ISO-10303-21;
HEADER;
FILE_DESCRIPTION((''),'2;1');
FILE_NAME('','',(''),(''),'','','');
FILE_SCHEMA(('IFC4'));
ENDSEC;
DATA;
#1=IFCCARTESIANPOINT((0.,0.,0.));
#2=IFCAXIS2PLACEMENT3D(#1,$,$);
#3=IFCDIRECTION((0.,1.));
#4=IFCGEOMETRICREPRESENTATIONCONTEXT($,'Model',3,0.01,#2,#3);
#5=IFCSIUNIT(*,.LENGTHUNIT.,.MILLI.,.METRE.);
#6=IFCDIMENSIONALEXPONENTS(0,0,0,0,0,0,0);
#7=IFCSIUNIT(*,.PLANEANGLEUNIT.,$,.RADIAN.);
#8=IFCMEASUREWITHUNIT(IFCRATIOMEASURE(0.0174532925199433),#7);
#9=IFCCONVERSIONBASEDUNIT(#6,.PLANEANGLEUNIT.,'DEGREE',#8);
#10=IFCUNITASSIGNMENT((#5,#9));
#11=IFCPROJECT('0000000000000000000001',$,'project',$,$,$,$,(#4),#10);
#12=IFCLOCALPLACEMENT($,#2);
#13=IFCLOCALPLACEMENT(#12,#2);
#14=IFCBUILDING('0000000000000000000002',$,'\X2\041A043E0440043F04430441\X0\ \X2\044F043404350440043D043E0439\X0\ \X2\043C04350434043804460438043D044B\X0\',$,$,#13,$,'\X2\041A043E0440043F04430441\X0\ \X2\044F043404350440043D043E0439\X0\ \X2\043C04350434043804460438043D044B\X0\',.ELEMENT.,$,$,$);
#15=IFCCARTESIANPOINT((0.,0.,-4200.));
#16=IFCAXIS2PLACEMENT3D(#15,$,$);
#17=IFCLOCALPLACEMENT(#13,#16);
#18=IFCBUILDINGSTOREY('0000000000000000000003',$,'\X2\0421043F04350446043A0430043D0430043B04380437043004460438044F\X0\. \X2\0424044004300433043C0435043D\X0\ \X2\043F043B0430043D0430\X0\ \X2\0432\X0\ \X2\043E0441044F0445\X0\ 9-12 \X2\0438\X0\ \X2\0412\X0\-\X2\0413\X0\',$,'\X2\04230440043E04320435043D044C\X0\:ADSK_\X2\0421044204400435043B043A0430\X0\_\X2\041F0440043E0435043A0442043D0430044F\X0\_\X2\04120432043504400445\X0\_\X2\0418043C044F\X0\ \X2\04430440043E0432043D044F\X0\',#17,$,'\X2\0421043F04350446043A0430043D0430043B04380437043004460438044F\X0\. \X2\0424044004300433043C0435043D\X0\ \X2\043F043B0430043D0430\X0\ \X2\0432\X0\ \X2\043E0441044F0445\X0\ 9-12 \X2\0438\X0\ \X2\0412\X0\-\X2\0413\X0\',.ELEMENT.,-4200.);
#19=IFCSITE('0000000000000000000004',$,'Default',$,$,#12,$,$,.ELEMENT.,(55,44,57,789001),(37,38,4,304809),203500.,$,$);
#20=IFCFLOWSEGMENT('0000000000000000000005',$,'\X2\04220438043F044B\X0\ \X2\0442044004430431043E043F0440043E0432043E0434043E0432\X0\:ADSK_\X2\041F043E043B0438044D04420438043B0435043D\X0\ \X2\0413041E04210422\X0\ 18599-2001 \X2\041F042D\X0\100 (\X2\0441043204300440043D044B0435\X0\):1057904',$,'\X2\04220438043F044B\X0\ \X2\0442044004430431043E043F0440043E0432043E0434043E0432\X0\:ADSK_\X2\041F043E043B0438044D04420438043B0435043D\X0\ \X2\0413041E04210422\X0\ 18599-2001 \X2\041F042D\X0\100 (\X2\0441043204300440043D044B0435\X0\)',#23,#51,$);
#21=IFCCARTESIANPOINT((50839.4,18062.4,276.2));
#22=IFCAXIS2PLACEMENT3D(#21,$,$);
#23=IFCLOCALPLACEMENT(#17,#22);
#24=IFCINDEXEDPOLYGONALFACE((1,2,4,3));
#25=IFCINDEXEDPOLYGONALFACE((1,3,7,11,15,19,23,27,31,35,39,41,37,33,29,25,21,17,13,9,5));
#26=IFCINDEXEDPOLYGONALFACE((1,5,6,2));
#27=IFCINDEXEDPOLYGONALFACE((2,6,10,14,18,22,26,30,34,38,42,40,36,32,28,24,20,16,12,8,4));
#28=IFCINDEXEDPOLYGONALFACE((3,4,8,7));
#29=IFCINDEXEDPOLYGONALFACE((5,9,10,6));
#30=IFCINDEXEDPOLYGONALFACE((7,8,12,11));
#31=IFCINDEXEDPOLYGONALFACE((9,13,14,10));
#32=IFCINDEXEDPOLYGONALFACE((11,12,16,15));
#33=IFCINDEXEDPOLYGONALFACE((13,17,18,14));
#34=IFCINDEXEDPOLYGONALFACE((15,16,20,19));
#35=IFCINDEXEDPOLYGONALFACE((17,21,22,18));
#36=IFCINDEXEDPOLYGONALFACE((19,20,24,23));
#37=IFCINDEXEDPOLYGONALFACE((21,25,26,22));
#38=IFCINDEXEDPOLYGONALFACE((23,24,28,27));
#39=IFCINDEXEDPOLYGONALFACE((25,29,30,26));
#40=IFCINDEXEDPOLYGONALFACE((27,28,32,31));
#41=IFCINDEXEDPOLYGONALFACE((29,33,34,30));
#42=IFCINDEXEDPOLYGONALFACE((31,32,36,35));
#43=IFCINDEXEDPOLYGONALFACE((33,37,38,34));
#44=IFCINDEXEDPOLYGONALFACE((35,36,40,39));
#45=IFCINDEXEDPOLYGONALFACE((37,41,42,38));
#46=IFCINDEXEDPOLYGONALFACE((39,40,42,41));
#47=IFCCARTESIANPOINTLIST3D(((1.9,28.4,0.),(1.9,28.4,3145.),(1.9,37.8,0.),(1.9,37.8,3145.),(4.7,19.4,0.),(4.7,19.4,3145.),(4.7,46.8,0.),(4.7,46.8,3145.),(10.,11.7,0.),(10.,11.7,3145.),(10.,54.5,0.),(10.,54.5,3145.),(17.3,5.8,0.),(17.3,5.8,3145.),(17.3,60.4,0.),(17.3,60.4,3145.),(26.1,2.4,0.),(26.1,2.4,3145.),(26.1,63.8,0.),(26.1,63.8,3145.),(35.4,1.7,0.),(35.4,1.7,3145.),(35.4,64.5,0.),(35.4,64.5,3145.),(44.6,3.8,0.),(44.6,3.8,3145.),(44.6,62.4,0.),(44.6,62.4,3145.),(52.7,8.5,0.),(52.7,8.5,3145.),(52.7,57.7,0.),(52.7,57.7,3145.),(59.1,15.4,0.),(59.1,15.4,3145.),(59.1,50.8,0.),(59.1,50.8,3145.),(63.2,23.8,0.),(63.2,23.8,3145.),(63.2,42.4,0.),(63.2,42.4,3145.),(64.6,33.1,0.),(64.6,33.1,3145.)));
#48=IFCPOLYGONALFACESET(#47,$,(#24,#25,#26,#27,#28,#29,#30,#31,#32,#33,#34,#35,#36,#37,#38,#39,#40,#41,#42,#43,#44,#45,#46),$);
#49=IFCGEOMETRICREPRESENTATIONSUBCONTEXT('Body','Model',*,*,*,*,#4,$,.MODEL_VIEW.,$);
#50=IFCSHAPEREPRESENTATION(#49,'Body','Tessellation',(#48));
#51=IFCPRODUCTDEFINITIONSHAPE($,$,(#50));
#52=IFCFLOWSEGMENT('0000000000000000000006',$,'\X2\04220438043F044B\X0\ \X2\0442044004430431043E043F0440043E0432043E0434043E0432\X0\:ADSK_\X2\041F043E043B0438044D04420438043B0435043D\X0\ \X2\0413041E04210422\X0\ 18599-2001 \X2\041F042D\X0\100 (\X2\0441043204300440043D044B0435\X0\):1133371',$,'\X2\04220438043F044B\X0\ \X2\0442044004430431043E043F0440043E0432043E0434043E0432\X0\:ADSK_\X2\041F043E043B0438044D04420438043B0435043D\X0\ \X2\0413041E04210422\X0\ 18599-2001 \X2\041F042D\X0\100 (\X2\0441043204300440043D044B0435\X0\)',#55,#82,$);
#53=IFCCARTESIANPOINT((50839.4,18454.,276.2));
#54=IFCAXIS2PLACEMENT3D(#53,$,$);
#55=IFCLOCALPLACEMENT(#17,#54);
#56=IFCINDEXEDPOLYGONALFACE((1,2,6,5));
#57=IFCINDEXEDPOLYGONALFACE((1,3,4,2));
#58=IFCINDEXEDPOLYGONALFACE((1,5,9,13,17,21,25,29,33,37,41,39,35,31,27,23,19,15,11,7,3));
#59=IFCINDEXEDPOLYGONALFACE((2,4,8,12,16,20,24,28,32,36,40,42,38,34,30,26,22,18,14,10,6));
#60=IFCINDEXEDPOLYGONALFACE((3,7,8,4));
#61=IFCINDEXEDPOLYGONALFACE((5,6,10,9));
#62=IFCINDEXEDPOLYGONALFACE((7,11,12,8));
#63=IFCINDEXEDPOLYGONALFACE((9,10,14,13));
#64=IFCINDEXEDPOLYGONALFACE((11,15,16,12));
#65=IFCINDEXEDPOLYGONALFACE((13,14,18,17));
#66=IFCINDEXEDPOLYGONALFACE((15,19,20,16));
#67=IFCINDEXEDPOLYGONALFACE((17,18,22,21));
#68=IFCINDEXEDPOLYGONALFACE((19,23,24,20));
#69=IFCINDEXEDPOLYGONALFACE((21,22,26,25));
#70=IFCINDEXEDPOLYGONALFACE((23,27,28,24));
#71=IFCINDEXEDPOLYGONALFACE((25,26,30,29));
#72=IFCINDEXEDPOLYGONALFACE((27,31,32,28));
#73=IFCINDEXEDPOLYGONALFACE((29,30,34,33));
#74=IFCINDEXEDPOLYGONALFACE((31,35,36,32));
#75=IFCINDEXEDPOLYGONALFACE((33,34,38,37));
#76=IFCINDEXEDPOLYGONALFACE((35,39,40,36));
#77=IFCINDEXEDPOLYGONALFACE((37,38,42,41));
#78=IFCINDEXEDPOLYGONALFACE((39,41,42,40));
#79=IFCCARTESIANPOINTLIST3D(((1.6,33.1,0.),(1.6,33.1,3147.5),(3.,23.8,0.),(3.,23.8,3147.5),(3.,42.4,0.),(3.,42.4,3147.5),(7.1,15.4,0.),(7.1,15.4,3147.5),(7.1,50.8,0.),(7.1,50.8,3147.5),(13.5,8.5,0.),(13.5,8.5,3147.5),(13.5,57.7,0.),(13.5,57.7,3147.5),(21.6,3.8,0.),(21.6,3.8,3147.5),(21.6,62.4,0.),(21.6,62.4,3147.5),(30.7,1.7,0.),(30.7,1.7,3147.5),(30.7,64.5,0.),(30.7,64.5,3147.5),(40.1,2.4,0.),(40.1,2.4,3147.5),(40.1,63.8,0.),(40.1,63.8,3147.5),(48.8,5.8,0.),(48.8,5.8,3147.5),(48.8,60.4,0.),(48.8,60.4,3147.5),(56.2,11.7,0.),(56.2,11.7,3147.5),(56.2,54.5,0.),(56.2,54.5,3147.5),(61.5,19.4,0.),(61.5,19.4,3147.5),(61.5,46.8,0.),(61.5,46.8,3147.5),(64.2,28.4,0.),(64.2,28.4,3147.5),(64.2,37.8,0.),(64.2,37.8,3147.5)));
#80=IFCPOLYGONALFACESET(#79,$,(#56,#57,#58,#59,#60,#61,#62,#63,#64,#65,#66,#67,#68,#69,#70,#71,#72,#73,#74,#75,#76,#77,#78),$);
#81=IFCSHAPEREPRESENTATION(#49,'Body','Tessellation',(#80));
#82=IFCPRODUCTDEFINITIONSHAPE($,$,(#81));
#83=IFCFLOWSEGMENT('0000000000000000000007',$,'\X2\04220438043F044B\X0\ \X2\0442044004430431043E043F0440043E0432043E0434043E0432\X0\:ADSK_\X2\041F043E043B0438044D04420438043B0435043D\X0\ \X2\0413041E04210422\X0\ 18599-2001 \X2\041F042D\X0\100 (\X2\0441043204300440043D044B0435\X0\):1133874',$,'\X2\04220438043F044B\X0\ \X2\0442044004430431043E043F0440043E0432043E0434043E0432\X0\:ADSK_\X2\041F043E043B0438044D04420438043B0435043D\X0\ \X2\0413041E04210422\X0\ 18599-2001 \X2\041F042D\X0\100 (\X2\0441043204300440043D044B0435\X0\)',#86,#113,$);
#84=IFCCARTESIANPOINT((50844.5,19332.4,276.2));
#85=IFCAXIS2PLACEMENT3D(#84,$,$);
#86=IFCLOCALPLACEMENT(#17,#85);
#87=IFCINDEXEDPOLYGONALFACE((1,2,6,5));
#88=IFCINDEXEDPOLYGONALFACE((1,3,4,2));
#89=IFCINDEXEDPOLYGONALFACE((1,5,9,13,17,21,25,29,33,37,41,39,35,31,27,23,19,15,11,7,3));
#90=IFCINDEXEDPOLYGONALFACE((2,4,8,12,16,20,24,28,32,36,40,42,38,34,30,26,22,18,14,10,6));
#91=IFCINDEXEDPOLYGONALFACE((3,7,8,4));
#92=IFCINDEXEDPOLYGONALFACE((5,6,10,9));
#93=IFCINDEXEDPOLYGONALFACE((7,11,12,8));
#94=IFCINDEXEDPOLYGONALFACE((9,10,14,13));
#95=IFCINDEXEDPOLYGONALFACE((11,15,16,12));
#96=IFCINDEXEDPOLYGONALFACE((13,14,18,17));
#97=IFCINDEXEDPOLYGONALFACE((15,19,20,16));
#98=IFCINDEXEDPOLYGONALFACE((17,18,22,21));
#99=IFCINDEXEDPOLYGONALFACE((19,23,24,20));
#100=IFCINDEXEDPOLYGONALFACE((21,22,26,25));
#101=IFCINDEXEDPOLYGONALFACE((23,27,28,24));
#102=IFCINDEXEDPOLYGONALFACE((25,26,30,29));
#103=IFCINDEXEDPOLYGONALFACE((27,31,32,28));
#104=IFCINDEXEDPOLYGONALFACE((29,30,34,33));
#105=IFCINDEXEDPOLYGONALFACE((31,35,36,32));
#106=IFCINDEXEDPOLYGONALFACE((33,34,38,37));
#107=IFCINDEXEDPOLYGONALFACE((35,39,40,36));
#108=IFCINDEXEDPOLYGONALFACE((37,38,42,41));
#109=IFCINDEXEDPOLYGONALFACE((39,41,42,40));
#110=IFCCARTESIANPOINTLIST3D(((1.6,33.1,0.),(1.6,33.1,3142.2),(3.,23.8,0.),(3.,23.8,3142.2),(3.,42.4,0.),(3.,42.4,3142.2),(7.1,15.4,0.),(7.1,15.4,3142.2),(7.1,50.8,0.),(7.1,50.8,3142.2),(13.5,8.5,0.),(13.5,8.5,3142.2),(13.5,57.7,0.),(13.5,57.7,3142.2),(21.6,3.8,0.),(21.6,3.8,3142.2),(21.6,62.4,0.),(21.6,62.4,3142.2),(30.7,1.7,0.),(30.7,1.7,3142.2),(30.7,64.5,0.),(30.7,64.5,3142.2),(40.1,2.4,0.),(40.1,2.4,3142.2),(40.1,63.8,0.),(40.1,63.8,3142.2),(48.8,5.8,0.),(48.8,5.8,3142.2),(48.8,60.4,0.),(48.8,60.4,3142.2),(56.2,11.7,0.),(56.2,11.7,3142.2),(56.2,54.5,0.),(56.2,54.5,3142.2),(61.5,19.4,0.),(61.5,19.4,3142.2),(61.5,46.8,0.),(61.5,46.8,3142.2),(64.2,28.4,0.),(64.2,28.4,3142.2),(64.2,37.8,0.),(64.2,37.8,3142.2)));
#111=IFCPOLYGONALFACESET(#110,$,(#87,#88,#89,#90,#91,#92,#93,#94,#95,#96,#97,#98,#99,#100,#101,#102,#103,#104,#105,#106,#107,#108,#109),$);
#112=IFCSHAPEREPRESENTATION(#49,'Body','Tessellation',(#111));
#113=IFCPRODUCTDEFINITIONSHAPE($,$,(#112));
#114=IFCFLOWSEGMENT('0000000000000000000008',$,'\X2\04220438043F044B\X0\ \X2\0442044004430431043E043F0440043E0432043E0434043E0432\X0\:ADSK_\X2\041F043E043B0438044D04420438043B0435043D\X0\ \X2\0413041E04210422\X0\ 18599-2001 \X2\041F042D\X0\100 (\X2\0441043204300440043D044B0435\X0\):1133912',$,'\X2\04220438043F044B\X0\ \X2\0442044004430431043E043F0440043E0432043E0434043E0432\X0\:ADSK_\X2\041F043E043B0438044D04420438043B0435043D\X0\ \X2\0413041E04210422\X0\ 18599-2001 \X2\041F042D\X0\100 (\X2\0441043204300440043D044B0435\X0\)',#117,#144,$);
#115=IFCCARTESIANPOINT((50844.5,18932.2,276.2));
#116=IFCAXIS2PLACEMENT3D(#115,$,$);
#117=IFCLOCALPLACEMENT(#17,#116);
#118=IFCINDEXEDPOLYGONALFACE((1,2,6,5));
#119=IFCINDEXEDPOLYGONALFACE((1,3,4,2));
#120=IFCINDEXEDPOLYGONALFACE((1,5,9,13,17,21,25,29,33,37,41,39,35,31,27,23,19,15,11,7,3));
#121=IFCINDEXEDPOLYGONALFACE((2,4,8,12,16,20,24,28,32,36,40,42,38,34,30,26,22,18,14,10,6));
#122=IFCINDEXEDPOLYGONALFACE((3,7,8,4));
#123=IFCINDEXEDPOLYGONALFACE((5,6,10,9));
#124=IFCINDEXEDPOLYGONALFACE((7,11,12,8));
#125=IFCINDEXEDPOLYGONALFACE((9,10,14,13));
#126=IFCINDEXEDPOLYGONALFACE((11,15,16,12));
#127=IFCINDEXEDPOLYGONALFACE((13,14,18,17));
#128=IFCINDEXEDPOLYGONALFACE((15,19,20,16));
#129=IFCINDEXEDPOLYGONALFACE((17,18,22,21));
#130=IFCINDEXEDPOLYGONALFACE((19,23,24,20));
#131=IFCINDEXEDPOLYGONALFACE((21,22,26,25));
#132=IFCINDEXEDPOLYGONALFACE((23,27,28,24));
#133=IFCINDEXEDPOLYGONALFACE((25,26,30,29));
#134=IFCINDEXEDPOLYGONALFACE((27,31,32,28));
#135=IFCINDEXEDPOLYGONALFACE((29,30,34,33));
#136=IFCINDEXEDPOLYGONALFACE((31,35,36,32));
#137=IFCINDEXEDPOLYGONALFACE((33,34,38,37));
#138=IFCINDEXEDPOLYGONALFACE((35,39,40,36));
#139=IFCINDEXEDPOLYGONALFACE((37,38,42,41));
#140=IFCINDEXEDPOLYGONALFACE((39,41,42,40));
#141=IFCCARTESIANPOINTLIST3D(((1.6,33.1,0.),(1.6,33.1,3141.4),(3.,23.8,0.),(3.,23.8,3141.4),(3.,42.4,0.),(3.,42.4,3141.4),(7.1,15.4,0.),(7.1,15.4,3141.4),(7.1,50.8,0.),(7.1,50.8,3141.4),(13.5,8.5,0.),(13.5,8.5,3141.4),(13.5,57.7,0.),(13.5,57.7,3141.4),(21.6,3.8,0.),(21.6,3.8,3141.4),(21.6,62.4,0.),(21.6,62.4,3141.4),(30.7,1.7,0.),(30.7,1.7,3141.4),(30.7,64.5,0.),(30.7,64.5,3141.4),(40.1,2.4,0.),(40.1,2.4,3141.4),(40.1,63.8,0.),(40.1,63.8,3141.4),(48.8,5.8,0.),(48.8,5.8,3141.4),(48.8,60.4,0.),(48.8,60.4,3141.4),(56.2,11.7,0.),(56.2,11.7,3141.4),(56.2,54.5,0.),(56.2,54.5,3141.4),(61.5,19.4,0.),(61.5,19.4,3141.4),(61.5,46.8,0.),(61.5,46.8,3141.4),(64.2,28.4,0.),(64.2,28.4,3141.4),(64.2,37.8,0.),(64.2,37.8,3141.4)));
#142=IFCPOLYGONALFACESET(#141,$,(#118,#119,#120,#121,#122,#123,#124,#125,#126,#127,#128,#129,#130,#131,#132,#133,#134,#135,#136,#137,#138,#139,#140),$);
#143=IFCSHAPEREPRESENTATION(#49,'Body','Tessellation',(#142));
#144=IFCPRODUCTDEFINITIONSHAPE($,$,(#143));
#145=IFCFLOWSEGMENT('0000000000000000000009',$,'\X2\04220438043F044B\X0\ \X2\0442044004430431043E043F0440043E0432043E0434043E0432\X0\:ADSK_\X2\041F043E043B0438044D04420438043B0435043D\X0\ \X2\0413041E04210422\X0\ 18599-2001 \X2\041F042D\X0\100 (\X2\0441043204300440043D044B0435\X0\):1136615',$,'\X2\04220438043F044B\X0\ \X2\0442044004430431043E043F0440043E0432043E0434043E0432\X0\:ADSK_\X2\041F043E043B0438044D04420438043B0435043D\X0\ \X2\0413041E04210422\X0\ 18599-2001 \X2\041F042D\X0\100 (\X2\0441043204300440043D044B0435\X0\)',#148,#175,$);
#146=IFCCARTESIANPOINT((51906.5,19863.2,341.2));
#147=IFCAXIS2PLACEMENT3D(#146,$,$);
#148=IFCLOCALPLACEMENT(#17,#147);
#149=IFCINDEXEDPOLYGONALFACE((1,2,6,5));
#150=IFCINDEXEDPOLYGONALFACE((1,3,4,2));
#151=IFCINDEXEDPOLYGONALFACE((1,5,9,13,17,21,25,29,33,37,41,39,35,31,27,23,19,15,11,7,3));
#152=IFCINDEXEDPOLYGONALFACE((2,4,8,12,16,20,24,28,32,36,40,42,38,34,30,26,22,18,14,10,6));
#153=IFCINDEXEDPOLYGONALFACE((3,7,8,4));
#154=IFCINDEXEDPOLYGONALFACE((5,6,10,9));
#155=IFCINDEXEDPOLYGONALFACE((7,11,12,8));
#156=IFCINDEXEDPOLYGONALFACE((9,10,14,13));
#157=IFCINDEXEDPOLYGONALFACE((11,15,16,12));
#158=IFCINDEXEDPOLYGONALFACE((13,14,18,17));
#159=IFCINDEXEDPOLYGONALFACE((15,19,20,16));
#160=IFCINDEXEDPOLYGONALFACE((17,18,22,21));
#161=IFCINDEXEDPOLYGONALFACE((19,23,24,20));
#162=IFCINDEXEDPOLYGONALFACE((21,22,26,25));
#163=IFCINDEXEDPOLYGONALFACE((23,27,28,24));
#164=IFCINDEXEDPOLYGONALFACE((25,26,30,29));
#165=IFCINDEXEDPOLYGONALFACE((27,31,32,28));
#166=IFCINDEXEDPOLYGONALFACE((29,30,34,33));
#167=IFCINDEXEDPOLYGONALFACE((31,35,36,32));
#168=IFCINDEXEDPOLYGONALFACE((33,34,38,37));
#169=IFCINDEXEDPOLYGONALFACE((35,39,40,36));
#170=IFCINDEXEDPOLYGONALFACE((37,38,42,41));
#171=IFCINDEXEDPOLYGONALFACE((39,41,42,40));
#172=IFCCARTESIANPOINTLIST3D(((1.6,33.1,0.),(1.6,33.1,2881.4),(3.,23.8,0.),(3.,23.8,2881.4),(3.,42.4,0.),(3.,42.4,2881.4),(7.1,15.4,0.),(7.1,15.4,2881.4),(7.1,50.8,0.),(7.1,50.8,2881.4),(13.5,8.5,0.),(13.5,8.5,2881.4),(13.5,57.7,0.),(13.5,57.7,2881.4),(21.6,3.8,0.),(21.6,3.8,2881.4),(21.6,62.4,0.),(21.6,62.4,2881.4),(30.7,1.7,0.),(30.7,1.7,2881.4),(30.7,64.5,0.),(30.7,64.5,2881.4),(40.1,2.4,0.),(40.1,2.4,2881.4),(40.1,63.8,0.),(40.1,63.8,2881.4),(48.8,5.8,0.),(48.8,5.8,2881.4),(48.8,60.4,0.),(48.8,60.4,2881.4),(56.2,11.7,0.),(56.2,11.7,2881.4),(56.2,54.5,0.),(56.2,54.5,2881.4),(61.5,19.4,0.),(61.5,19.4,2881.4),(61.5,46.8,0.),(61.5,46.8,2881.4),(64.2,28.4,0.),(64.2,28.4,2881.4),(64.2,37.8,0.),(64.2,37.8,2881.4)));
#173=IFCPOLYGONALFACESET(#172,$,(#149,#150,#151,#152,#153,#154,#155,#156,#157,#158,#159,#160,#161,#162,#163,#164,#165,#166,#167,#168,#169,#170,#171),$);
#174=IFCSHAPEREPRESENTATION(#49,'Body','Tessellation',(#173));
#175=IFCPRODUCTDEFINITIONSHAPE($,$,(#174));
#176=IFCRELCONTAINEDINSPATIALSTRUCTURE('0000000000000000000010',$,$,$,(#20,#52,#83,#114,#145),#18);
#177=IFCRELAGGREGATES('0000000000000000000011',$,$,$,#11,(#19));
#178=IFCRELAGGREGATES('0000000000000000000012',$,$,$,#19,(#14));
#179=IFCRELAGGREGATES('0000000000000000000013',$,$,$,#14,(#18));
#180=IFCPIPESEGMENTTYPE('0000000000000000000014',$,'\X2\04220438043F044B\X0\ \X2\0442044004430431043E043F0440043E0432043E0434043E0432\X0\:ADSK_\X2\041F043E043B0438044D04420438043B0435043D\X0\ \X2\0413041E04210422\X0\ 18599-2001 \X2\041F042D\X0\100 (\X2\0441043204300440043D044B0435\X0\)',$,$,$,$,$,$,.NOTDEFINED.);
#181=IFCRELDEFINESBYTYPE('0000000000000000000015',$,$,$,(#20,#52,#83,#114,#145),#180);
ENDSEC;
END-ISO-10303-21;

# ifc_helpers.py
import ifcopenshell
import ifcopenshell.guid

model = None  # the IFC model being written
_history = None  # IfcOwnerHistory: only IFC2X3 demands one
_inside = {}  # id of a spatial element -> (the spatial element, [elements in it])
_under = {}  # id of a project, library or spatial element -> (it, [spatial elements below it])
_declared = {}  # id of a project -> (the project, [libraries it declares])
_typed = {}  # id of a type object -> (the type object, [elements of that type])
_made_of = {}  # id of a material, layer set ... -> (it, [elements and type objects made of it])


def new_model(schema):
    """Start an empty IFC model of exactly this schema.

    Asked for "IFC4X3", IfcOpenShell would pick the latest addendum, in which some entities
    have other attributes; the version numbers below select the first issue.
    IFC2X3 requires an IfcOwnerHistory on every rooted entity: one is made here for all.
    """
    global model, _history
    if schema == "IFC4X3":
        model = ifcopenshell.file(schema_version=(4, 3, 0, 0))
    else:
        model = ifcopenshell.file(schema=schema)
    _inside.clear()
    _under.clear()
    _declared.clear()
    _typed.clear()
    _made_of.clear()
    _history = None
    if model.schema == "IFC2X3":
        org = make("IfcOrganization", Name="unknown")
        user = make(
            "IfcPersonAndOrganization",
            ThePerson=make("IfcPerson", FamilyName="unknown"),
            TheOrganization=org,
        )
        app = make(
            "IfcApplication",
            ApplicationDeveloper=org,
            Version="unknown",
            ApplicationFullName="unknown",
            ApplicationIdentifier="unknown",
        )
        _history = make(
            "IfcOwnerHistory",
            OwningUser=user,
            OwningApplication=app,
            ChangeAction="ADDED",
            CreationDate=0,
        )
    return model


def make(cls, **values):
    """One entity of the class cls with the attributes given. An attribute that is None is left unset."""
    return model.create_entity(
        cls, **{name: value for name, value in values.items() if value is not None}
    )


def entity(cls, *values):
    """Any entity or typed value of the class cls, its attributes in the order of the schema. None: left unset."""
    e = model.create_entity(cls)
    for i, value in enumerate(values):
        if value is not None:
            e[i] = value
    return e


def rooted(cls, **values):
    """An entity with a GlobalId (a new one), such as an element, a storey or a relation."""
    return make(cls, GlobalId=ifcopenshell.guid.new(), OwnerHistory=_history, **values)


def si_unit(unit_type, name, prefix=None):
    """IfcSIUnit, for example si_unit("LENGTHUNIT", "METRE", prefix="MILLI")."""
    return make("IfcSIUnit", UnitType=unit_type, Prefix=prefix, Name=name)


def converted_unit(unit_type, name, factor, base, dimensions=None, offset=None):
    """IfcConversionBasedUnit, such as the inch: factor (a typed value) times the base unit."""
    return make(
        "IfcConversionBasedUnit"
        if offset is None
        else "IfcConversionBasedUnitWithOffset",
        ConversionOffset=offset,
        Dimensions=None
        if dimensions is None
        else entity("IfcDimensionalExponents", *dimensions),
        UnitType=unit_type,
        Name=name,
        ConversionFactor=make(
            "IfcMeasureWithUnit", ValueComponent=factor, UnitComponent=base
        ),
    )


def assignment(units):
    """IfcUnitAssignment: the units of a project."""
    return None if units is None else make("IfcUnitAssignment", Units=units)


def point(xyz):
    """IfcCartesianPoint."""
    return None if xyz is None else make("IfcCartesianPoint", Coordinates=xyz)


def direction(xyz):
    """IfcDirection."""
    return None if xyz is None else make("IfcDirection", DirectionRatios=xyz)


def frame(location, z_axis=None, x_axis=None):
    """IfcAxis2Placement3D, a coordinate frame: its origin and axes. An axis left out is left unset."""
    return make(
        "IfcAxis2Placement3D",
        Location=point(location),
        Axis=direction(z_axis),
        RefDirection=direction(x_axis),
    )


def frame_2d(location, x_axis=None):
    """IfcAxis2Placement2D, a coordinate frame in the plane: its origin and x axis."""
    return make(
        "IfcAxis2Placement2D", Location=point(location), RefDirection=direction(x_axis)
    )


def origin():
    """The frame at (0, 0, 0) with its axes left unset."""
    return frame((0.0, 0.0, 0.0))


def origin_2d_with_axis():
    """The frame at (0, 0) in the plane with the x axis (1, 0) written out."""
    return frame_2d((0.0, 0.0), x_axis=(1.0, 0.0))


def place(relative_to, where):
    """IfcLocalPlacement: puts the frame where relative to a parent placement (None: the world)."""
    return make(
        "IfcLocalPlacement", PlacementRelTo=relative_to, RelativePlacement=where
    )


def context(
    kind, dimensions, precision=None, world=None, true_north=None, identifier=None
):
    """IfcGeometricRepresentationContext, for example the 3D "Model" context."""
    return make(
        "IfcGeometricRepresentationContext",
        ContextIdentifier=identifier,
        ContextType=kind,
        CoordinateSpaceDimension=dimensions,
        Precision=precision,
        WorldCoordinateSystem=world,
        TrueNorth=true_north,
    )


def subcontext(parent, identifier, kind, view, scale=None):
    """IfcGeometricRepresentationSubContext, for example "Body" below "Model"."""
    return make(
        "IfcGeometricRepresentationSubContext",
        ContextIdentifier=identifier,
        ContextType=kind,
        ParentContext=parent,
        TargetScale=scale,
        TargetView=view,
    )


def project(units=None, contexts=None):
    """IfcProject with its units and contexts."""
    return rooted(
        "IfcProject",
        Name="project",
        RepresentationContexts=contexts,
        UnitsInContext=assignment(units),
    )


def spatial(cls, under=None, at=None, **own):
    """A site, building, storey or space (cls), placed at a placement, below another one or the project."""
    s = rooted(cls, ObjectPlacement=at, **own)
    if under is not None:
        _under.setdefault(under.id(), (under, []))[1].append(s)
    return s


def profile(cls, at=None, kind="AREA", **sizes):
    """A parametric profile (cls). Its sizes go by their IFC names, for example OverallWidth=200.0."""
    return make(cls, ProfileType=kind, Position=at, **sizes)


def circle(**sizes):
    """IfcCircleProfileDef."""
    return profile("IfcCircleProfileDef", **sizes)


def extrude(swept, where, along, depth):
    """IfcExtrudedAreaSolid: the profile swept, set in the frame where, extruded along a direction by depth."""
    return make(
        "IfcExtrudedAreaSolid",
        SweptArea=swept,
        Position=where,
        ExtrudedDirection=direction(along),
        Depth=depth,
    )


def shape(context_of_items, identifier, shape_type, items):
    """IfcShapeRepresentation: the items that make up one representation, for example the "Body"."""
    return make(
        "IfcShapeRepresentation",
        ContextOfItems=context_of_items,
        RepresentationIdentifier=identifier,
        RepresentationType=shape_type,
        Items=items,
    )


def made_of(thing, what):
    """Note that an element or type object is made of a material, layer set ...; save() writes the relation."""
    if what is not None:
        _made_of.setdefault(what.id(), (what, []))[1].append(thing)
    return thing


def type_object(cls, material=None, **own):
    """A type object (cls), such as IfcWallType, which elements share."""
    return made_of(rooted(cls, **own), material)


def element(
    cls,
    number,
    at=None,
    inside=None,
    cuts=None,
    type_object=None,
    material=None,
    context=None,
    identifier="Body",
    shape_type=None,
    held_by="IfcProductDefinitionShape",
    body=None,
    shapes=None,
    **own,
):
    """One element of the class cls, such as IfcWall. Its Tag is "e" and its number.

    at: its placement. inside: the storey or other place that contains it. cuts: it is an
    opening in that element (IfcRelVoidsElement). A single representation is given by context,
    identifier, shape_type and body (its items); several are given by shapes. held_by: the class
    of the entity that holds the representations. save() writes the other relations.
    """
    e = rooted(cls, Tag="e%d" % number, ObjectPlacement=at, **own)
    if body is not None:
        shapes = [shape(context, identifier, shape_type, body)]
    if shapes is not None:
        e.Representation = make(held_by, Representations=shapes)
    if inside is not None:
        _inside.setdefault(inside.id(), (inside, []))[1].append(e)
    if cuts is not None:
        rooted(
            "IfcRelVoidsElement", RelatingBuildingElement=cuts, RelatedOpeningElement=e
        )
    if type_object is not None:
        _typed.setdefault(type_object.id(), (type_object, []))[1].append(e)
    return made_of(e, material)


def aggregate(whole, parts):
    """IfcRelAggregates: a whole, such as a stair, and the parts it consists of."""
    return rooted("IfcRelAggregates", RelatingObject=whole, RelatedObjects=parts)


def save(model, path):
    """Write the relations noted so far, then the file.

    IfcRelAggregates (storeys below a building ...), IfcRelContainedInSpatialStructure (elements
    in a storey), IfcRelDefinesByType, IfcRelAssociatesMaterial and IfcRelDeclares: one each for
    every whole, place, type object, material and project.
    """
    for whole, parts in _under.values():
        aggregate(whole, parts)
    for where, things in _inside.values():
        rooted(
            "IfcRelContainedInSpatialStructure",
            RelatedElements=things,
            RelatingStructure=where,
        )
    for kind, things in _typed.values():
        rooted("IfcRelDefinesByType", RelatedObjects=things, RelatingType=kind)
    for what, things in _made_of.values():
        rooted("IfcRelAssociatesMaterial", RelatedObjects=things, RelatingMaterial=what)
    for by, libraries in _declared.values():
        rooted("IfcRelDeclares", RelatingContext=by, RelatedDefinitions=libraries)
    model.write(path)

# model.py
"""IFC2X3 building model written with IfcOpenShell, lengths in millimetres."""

from ifc_helpers import new_model, entity, si_unit, converted_unit, direction, frame, frame_2d, origin, origin_2d_with_axis, place, context, subcontext, project, spatial, circle, extrude, type_object, element, save


model = new_model("IFC2X3")

# Units and contexts
model_context = context("Model", 3, precision=0.01, world=origin(), true_north=direction((0.0, 1.0)))
body_context = subcontext(model_context, "Body", "Model", "MODEL_VIEW")
ifc_project = project(units=[si_unit("LENGTHUNIT", "METRE", prefix="MILLI"), converted_unit("PLANEANGLEUNIT", "DEGREE", entity("IfcRatioMeasure", 0.0174532925199433), si_unit("PLANEANGLEUNIT", "RADIAN"), dimensions=[0, 0, 0, 0, 0, 0, 0])], contexts=[model_context])

# Site, building, storey
site_placement = place(None, frame((0.0, 0.0, 0.0)))
site = spatial("IfcSite", under=ifc_project, at=site_placement, Name="Default", CompositionType="ELEMENT", RefLatitude=(55, 44, 57, 789001), RefLongitude=(37, 38, 4, 304809), RefElevation=203500.0)
building_placement = place(site_placement, origin())
building = spatial("IfcBuilding", under=site, at=building_placement, Name="Корпус ядерной медицины", LongName="Корпус ядерной медицины", CompositionType="ELEMENT")
storey_placement = place(building_placement, frame((0.0, 0.0, -4200.0)))
storey = spatial("IfcBuildingStorey", under=building, at=storey_placement, Name="Спецканализация. Фрагмен плана в осях 9-12 и В-Г", ObjectType="Уровень:ADSK_Стрелка_Проектная_Вверх_Имя уровня", LongName="Спецканализация. Фрагмен плана в осях 9-12 и В-Г", CompositionType="ELEMENT", Elevation=-4200.0)

# Flow segments
pipe_segment_type = type_object("IfcPipeSegmentType", Name="Типы трубопроводов:ADSK_Полиэтилен ГОСТ 18599-2001 ПЭ100 (сварные)", PredefinedType="NOTDEFINED")
flow_segment_1_placement = place(storey_placement, frame((50839.4, 18062.4, 276.2)))
element("IfcFlowSegment", 1, at=flow_segment_1_placement, inside=storey, type_object=pipe_segment_type, Name="Типы трубопроводов:ADSK_Полиэтилен ГОСТ 18599-2001 ПЭ100 (сварные):1057904", ObjectType="Типы трубопроводов:ADSK_Полиэтилен ГОСТ 18599-2001 ПЭ100 (сварные)", context=body_context, shape_type="SweptSolid", body=[
    extrude(circle(Radius=31.5, at=frame_2d((0.0, 0.0), x_axis=(1.0, 0.0))), frame((33.1, 33.1, 0.0)), (0.0, 0.0, 1.0), 3145.0),
])
flow_segment_2_placement = place(storey_placement, frame((50839.4, 18454.0, 276.2)))
element("IfcFlowSegment", 2, at=flow_segment_2_placement, inside=storey, type_object=pipe_segment_type, Name="Типы трубопроводов:ADSK_Полиэтилен ГОСТ 18599-2001 ПЭ100 (сварные):1133371", ObjectType="Типы трубопроводов:ADSK_Полиэтилен ГОСТ 18599-2001 ПЭ100 (сварные)", context=body_context, shape_type="SweptSolid", body=[
    extrude(circle(Radius=31.5, at=frame_2d((0.0, 0.0), x_axis=(1.0, 0.0))), frame((33.1, 33.1, 0.0), z_axis=(0.0, 0.0, 1.0), x_axis=(-1.0, 0.0, 0.0)), (0.0, 0.0, 1.0), 3147.5),
])
flow_segment_3_placement = place(storey_placement, frame((50844.5, 19332.4, 276.2)))
element("IfcFlowSegment", 3, at=flow_segment_3_placement, inside=storey, type_object=pipe_segment_type, Name="Типы трубопроводов:ADSK_Полиэтилен ГОСТ 18599-2001 ПЭ100 (сварные):1133874", ObjectType="Типы трубопроводов:ADSK_Полиэтилен ГОСТ 18599-2001 ПЭ100 (сварные)", context=body_context, shape_type="SweptSolid", body=[
    extrude(circle(Radius=31.5, at=origin_2d_with_axis()), frame((33.1, 33.1, 0.0), z_axis=(0.0, 0.0, 1.0), x_axis=(-1.0, 0.0, 0.0)), (0.0, 0.0, 1.0), 3142.2),
])
flow_segment_4_placement = place(storey_placement, frame((50844.5, 18932.2, 276.2)))
element("IfcFlowSegment", 4, at=flow_segment_4_placement, inside=storey, type_object=pipe_segment_type, Name="Типы трубопроводов:ADSK_Полиэтилен ГОСТ 18599-2001 ПЭ100 (сварные):1133912", ObjectType="Типы трубопроводов:ADSK_Полиэтилен ГОСТ 18599-2001 ПЭ100 (сварные)", context=body_context, shape_type="SweptSolid", body=[
    extrude(circle(Radius=31.5, at=frame_2d((0.0, 0.0), x_axis=(1.0, 0.0))), frame((33.1, 33.1, 0.0), z_axis=(0.0, 0.0, 1.0), x_axis=(-1.0, 0.0, 0.0)), (0.0, 0.0, 1.0), 3141.4),
])
flow_segment_5_placement = place(storey_placement, frame((51906.5, 19863.2, 341.2)))
element("IfcFlowSegment", 5, at=flow_segment_5_placement, inside=storey, type_object=pipe_segment_type, Name="Типы трубопроводов:ADSK_Полиэтилен ГОСТ 18599-2001 ПЭ100 (сварные):1136615", ObjectType="Типы трубопроводов:ADSK_Полиэтилен ГОСТ 18599-2001 ПЭ100 (сварные)", context=body_context, shape_type="SweptSolid", body=[
    extrude(circle(Radius=31.5, at=origin_2d_with_axis()), frame((33.1, 33.1, 0.0), z_axis=(0.0, 0.0, 1.0), x_axis=(-1.0, 0.0, 0.0)), (0.0, 0.0, 1.0), 2881.4),
])

save(model, "model.ifc")
